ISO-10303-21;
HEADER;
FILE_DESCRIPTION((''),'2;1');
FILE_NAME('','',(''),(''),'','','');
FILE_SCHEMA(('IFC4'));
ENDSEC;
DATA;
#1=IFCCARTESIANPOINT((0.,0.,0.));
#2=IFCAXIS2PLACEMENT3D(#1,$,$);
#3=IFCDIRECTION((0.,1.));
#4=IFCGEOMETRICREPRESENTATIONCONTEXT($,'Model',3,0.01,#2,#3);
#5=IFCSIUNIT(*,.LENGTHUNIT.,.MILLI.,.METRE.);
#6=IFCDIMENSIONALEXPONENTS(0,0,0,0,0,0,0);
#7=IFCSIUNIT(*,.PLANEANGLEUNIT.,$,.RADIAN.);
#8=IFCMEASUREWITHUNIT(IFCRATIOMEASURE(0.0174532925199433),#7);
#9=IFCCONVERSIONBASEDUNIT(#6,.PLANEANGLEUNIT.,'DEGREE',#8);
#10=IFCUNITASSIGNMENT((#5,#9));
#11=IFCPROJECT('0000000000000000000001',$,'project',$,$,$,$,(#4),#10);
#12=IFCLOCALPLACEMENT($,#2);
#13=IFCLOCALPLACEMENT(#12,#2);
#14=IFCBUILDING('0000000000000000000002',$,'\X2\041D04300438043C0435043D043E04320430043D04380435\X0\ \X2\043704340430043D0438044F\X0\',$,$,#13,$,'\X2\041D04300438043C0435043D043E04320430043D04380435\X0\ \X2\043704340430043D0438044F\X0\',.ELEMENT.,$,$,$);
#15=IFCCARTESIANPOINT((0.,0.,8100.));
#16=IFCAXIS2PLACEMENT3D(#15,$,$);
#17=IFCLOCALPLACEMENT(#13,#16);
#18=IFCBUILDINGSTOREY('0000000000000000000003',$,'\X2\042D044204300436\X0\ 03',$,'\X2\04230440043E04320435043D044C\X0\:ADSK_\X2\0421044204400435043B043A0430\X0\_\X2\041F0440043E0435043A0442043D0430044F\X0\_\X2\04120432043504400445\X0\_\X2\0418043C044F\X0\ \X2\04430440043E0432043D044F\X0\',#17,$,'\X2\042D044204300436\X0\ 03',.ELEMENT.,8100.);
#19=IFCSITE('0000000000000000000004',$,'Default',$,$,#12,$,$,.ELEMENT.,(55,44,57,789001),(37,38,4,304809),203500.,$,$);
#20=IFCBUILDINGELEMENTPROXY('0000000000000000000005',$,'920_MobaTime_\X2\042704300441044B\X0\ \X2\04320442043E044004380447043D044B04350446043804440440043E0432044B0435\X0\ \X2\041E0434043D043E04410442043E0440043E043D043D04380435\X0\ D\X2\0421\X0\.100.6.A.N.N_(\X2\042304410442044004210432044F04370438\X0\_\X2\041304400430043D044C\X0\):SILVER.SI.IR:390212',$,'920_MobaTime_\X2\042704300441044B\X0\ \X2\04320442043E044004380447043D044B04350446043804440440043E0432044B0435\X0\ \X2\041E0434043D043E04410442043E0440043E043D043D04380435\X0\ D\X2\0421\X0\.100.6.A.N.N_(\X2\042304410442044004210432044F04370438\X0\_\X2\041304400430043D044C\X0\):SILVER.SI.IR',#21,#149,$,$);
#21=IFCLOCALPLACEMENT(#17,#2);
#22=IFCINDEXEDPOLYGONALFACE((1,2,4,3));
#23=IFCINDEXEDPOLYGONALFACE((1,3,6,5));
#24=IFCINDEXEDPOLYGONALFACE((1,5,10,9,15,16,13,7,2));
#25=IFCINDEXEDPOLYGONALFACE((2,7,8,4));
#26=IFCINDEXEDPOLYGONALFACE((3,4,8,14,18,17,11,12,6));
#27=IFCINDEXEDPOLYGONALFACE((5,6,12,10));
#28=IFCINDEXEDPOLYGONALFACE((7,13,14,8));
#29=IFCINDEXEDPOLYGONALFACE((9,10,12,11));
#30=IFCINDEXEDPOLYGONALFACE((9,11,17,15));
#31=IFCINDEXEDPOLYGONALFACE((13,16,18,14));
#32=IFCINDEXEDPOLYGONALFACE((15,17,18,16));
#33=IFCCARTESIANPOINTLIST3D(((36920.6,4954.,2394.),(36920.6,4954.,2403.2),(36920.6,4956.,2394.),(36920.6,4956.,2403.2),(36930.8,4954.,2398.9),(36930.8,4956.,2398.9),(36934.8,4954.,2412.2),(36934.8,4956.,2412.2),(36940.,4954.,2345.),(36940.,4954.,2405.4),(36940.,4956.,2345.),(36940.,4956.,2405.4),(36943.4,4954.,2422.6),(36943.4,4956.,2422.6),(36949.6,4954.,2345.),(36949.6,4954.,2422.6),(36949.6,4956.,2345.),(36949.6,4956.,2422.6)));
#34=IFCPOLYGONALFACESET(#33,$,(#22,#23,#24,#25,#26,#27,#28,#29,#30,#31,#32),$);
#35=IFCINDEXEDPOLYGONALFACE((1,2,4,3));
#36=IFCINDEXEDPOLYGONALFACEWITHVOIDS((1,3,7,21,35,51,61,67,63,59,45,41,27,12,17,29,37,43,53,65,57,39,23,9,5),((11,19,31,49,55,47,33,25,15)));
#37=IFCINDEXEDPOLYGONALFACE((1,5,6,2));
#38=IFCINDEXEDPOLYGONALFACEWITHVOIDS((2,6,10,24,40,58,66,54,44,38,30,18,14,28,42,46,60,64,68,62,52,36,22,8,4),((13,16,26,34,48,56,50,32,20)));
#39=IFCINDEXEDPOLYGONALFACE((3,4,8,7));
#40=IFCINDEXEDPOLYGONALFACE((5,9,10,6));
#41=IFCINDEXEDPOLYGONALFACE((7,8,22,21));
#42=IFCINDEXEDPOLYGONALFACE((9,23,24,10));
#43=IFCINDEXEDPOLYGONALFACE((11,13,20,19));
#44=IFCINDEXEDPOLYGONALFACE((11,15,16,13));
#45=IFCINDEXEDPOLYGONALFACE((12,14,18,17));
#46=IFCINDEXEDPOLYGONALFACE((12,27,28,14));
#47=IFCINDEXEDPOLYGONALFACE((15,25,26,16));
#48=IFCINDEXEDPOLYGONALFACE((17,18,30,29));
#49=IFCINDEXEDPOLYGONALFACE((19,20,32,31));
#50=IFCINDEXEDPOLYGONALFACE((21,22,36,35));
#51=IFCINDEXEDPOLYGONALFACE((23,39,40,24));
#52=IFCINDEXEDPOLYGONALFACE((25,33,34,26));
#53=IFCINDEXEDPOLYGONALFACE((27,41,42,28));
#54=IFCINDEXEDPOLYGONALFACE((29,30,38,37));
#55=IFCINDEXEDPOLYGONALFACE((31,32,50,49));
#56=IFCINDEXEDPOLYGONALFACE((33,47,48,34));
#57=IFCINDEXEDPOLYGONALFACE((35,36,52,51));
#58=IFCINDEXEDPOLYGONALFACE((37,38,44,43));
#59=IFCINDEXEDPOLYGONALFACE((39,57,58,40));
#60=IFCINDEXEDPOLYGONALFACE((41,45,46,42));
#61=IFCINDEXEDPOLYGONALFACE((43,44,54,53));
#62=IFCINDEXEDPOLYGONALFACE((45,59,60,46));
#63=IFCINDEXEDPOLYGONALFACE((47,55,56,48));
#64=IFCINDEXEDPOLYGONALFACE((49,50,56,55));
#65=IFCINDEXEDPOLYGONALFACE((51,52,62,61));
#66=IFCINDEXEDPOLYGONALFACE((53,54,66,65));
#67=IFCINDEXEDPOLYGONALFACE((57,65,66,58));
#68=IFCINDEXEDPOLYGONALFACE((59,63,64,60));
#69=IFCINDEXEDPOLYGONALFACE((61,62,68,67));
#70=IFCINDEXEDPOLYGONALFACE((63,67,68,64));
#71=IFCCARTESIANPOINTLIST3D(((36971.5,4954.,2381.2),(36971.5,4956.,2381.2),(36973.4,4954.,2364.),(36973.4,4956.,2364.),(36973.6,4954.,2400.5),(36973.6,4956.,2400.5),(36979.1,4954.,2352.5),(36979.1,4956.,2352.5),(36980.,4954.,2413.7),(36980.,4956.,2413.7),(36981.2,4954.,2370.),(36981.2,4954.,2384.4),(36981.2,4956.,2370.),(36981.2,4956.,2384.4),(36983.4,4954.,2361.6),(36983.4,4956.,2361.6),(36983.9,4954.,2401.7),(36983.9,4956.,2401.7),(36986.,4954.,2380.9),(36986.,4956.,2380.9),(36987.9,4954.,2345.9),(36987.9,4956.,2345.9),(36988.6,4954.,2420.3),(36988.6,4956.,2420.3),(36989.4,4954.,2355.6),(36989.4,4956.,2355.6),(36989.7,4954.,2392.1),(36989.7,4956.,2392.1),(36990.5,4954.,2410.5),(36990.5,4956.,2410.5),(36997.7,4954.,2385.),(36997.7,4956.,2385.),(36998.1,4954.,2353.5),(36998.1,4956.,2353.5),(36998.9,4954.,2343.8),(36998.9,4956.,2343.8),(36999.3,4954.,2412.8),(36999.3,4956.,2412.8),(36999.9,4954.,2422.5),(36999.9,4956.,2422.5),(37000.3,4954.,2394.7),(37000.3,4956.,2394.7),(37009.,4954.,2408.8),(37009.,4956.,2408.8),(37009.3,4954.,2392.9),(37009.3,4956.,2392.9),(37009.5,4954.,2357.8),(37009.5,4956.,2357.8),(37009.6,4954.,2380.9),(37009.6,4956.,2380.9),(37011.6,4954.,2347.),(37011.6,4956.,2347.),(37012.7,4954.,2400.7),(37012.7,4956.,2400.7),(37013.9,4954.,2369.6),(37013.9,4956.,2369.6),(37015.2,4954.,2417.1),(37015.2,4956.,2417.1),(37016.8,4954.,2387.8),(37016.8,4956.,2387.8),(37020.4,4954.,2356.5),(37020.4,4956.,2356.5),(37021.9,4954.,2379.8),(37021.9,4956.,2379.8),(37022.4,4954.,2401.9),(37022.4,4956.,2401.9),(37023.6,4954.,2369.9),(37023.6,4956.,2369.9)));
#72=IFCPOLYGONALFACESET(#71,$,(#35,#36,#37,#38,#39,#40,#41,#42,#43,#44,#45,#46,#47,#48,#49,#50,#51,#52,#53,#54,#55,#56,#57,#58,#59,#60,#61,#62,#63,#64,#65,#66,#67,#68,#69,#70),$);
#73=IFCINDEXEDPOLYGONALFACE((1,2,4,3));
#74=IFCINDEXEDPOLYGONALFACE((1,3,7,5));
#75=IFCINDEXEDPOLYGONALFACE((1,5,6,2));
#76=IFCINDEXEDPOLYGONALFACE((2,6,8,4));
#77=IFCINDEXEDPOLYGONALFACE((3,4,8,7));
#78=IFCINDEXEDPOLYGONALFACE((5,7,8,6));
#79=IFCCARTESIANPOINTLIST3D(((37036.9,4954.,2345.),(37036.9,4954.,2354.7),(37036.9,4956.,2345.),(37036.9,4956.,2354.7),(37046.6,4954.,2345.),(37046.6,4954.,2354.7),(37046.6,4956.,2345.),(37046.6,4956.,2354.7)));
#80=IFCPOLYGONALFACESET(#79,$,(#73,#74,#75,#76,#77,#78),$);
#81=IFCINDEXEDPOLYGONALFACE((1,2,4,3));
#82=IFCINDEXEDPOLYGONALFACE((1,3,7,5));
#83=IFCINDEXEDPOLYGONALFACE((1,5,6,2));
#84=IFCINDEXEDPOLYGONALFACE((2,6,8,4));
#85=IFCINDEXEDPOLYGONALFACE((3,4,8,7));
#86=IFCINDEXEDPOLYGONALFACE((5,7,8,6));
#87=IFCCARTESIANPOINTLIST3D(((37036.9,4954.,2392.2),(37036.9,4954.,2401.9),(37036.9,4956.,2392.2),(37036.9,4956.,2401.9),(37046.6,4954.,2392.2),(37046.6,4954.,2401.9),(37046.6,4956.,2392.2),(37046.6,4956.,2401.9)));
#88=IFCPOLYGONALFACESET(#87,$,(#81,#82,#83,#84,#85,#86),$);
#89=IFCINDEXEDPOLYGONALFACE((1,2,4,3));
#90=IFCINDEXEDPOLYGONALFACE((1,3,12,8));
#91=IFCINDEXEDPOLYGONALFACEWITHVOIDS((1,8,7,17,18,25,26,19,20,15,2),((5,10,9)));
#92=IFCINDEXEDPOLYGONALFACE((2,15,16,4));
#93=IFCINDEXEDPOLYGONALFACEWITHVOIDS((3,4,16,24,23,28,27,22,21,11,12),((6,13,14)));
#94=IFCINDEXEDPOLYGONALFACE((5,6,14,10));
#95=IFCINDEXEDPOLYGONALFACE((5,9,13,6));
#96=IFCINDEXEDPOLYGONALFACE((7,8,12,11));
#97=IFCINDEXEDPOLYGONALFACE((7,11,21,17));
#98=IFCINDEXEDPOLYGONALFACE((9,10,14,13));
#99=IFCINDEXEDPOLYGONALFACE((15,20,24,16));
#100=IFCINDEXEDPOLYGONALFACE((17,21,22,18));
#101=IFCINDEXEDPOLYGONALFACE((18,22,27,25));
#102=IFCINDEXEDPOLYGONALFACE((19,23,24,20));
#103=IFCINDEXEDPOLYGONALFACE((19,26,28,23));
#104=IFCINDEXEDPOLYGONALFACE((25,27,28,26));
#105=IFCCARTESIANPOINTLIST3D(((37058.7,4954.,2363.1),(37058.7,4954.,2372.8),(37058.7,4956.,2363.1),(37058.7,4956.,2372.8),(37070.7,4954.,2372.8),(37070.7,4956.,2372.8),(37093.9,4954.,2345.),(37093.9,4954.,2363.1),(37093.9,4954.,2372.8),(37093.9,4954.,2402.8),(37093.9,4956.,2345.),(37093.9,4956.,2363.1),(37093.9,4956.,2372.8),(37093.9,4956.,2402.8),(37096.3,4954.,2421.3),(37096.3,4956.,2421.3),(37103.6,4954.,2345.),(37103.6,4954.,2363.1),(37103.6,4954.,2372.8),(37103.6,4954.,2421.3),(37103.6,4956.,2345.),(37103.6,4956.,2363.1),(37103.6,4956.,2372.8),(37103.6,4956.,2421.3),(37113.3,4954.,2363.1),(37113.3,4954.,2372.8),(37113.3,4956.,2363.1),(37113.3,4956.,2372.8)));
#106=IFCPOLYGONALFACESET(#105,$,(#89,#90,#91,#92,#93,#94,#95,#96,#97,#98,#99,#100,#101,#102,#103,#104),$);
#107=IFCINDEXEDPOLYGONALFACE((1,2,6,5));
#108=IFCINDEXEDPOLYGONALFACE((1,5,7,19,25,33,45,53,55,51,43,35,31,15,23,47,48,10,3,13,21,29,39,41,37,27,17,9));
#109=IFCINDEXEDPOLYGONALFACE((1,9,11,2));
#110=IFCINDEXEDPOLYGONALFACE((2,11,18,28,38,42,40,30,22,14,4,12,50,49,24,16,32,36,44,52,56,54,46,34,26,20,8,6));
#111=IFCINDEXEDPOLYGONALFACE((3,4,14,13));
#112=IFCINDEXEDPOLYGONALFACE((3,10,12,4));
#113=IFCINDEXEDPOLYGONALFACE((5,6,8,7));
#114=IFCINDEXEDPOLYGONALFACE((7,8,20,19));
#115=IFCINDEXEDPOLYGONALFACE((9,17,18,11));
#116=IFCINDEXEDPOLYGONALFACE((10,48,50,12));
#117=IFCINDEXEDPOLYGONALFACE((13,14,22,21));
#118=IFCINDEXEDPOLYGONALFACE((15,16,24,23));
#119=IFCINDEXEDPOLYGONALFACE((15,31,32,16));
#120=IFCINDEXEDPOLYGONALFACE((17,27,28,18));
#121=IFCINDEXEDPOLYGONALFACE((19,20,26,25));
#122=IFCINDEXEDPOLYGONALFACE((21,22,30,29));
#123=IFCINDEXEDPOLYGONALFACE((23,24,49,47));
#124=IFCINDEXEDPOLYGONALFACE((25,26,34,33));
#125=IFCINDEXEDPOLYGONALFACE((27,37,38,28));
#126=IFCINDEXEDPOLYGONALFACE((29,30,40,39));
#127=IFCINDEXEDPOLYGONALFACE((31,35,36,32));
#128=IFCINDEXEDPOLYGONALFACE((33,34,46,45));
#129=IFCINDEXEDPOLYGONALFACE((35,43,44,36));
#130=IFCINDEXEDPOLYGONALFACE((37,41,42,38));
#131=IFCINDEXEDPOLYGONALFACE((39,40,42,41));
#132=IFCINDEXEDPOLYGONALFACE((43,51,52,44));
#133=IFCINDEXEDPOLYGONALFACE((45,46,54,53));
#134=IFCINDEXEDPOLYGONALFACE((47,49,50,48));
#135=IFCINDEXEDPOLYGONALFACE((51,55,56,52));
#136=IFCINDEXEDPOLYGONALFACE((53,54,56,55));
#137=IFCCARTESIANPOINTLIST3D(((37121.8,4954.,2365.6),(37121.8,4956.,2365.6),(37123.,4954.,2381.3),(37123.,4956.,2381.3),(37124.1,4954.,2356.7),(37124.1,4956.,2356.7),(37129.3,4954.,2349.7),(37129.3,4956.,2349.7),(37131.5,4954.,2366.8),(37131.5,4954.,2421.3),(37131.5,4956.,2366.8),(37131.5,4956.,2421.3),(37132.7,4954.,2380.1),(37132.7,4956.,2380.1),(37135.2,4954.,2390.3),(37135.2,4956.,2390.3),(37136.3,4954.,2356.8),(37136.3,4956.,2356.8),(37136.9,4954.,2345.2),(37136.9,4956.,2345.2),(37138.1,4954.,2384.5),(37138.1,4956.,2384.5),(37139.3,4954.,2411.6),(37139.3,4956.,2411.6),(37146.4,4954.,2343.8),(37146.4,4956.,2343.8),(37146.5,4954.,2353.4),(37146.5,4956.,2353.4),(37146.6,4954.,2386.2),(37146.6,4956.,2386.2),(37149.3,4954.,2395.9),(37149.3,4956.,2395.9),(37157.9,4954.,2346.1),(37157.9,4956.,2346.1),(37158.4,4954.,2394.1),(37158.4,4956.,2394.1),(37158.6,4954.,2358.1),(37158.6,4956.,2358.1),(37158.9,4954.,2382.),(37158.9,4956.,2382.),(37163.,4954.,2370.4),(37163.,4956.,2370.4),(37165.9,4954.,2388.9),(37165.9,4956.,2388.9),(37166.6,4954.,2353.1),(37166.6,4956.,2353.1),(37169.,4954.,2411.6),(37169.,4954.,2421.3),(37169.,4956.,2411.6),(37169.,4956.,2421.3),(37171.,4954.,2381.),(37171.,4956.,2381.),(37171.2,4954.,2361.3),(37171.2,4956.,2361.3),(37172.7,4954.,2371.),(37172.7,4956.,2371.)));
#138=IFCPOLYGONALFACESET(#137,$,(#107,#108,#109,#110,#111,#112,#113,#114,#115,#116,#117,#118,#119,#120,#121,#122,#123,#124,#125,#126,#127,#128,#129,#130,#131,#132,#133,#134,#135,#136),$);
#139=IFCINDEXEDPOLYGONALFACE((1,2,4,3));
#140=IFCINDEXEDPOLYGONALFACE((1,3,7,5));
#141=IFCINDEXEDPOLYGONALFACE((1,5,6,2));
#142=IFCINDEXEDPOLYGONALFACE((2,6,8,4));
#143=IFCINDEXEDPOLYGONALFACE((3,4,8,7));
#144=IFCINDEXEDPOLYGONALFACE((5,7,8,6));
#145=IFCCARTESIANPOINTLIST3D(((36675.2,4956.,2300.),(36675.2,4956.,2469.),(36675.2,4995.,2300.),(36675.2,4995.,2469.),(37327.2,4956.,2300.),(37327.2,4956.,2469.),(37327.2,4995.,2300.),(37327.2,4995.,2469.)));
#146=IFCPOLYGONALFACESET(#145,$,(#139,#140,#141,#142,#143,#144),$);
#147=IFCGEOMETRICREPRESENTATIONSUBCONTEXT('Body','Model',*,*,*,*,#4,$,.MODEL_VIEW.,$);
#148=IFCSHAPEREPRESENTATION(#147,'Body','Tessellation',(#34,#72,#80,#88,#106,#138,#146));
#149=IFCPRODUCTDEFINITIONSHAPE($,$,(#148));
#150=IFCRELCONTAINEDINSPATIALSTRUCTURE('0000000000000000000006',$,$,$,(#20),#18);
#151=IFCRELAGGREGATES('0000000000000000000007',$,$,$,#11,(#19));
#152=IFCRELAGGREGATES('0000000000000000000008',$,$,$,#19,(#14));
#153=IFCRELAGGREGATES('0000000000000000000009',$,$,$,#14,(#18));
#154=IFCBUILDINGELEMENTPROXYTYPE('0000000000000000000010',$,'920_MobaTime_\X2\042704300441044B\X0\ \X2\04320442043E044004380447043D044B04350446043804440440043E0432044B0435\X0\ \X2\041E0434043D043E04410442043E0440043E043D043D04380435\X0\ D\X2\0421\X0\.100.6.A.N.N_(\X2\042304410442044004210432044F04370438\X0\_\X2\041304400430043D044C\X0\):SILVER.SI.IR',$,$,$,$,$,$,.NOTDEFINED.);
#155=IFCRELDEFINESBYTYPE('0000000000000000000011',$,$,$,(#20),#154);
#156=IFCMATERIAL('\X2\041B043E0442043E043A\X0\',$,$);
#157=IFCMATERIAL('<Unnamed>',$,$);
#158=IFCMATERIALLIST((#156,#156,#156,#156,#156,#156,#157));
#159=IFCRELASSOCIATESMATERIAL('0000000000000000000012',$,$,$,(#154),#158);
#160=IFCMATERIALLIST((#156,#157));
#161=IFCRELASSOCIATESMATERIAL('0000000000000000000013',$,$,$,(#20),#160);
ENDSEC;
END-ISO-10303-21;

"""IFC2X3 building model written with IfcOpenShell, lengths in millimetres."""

from ifc_helpers import new_model, entity, si_unit, converted_unit, direction, frame, origin, origin_2d_with_axis, place, context, subcontext, project, spatial, polyline, rectangle, outline, extrude, source, transform, mapped, material, material_list, type_object, type_shapes, element, save


model = new_model("IFC2X3")

# Units and contexts
model_context = context("Model", 3, precision=0.01, world=origin(), true_north=direction((0.0, 1.0)))
body_context = subcontext(model_context, "Body", "Model", "MODEL_VIEW")
ifc_project = project(units=[si_unit("LENGTHUNIT", "METRE", prefix="MILLI"), converted_unit("PLANEANGLEUNIT", "DEGREE", entity("IfcRatioMeasure", 0.0174532925199433), si_unit("PLANEANGLEUNIT", "RADIAN"), dimensions=[0, 0, 0, 0, 0, 0, 0])], contexts=[model_context])

# Site, building, storey
site_placement = place(None, origin())
site = spatial("IfcSite", under=ifc_project, at=site_placement, Name="Default", CompositionType="ELEMENT", RefLatitude=(55, 44, 57, 789001), RefLongitude=(37, 38, 4, 304809), RefElevation=203500.0)
building_placement = place(site_placement, origin())
building = spatial("IfcBuilding", under=site, at=building_placement, Name="Наименование здания", LongName="Наименование здания", CompositionType="ELEMENT")
storey_placement = place(building_placement, frame((0.0, 0.0, 8100.0)))
storey = spatial("IfcBuildingStorey", under=building, at=storey_placement, Name="Этаж 03", ObjectType="Уровень:ADSK_Стрелка_Проектная_Вверх_Имя уровня", LongName="Этаж 03", CompositionType="ELEMENT", Elevation=8100.0)

# Building element proxy
ifc_material_1 = material(Name="Лоток")
ifc_material_2 = material(Name="<Unnamed>")
ifc_material_list_1 = material_list([ifc_material_1, ifc_material_1, ifc_material_1, ifc_material_1, ifc_material_1, ifc_material_1, ifc_material_2])
building_element_proxy_type = type_object("IfcBuildingElementProxyType", Name="920_MobaTime_Часы вторичныецифровые Односторонние DС.100.6.A.N.N_(УстрСвязи_Грань):SILVER.SI.IR", PredefinedType="NOTDEFINED", material=ifc_material_list_1)
shared_shape = source(origin(), body_context, "Body", "SweptSolid", [
    extrude(outline(polyline([(-49.3, -13.1), (28.2, -13.1), (28.2, -6.8), (17.9, 1.8), (8.8, 16.0), (-0.3, 16.0), (4.6, 5.8), (11.1, -3.4), (-49.3, -3.4), (-49.3, -13.1)])), frame((-64.6, 9.8, 39.0), z_axis=(0.0, 0.0, 1.0), x_axis=(0.0, 1.0, 0.0)), (0.0, 0.0, 1.0), 2.0),
    extrude(outline(polyline([(2.2, -27.6), (19.0, -27.6), (30.5, -16.1), (33.3, -4.9), (31.0, 5.8), (21.8, 17.2), (5.2, 27.3), (-11.1, 33.0), (-24.0, 32.7), (-33.6, 27.6), (-40.3, 18.6), (-42.8, 5.7), (-38.0, -6.3), (-27.2, -14.9), (-17.5, -17.7), (-8.2, -16.4), (-0.3, -11.9), (5.1, -4.5), (7.3, 6.2), (4.0, 17.2), (18.4, 7.3), (23.6, -2.4), (22.0, -11.4), (14.2, -18.4), (5.3, -18.3), (2.2, -27.6)]), holes=[polyline([(-9.0, 23.3), (-1.3, 14.3), (-2.5, 2.0), (-11.4, -7.0), (-23.4, -6.0), (-32.2, 2.9), (-31.2, 15.1), (-25.6, 22.1), (-17.5, 24.9), (-9.0, 23.3)])]), frame((-2.7, 3.6, 39.0), z_axis=(0.0, 0.0, 1.0), x_axis=(-0.427649, 0.903945, 0.0)), (0.0, 0.0, 1.0), 2.0),
    extrude(rectangle(XDim=9.7, YDim=9.7, at=origin_2d_with_axis()), frame((40.6, -34.7, 39.0)), (0.0, 0.0, 1.0), 2.0),
    extrude(rectangle(XDim=9.7, YDim=9.7, at=origin_2d_with_axis()), frame((40.6, 12.6, 39.0)), (0.0, 0.0, 1.0), 2.0),
    extrude(outline(polyline([(-0.9, -28.1), (8.8, -28.1), (8.8, -9.9), (18.5, -9.9), (18.5, -0.2), (8.8, -0.2), (8.8, 48.3), (1.5, 48.3), (-36.0, -0.2), (-36.0, -9.9), (-0.9, -9.9), (-0.9, -28.1)]), holes=[polyline([(-0.9, -0.2), (-24.1, -0.2), (-0.9, 29.7), (-0.9, -0.2)])]), frame((93.6, -11.4, 39.0)), (0.0, 0.0, 1.0), 2.0),
    extrude(outline(polyline([(3.3, -28.3), (12.5, -28.3), (20.5, -25.0), (26.8, -18.9), (30.7, -10.0), (31.4, 1.6), (26.9, 11.8), (20.1, 18.4), (11.1, 22.3), (1.0, 23.3), (-7.9, 20.4), (-14.9, 14.5), (-18.9, 6.2), (-17.1, -9.0), (-36.7, 0.5), (-29.1, 29.2), (-38.5, 31.7), (-48.1, -4.6), (-11.6, -23.1), (-8.0, -14.0), (-10.8, -7.6), (-10.2, 1.1), (-3.0, 11.8), (9.2, 12.8), (20.0, 5.5), (21.4, -7.5), (15.5, -16.4), (4.6, -18.6), (3.3, -28.3)])), frame((147.1, -8.5, 39.0), z_axis=(0.0, 0.0, 1.0), x_axis=(0.256974, -0.966418, 0.0)), (0.0, 0.0, 1.0), 2.0),
    extrude(rectangle(XDim=652.0, YDim=169.0, at=origin_2d_with_axis()), frame((0.0, 0.0, 0.0), z_axis=(0.0, 0.0, 1.0), x_axis=(-1.0, 0.0, 0.0)), (0.0, 0.0, 1.0), 39.0),
])
type_shapes(building_element_proxy_type, [shared_shape])
ifc_material_list_2 = material_list([ifc_material_1, ifc_material_2])
for number, where, z_axis, x_axis, name in (
    (1, (37001.2, 4995.0, 2384.5), (0.0, -1.0, 0.0), (1.0, 0.0, 0.0), "920_MobaTime_Часы вторичныецифровые Односторонние DС.100.6.A.N.N_(УстрСвязи_Грань):SILVER.SI.IR:390212"),
):
    element("IfcBuildingElementProxy", number, at=place(storey_placement, frame(where, z_axis=z_axis, x_axis=x_axis)), inside=storey, type_object=building_element_proxy_type, material=ifc_material_list_2, Name=name, ObjectType="920_MobaTime_Часы вторичныецифровые Односторонние DС.100.6.A.N.N_(УстрСвязи_Грань):SILVER.SI.IR", context=body_context, shape_type="MappedRepresentation", body=[
        mapped(shared_shape, transform((0.0, 0.0, 0.0), scale=1.0)),
    ])

save(model, "model.ifc")
